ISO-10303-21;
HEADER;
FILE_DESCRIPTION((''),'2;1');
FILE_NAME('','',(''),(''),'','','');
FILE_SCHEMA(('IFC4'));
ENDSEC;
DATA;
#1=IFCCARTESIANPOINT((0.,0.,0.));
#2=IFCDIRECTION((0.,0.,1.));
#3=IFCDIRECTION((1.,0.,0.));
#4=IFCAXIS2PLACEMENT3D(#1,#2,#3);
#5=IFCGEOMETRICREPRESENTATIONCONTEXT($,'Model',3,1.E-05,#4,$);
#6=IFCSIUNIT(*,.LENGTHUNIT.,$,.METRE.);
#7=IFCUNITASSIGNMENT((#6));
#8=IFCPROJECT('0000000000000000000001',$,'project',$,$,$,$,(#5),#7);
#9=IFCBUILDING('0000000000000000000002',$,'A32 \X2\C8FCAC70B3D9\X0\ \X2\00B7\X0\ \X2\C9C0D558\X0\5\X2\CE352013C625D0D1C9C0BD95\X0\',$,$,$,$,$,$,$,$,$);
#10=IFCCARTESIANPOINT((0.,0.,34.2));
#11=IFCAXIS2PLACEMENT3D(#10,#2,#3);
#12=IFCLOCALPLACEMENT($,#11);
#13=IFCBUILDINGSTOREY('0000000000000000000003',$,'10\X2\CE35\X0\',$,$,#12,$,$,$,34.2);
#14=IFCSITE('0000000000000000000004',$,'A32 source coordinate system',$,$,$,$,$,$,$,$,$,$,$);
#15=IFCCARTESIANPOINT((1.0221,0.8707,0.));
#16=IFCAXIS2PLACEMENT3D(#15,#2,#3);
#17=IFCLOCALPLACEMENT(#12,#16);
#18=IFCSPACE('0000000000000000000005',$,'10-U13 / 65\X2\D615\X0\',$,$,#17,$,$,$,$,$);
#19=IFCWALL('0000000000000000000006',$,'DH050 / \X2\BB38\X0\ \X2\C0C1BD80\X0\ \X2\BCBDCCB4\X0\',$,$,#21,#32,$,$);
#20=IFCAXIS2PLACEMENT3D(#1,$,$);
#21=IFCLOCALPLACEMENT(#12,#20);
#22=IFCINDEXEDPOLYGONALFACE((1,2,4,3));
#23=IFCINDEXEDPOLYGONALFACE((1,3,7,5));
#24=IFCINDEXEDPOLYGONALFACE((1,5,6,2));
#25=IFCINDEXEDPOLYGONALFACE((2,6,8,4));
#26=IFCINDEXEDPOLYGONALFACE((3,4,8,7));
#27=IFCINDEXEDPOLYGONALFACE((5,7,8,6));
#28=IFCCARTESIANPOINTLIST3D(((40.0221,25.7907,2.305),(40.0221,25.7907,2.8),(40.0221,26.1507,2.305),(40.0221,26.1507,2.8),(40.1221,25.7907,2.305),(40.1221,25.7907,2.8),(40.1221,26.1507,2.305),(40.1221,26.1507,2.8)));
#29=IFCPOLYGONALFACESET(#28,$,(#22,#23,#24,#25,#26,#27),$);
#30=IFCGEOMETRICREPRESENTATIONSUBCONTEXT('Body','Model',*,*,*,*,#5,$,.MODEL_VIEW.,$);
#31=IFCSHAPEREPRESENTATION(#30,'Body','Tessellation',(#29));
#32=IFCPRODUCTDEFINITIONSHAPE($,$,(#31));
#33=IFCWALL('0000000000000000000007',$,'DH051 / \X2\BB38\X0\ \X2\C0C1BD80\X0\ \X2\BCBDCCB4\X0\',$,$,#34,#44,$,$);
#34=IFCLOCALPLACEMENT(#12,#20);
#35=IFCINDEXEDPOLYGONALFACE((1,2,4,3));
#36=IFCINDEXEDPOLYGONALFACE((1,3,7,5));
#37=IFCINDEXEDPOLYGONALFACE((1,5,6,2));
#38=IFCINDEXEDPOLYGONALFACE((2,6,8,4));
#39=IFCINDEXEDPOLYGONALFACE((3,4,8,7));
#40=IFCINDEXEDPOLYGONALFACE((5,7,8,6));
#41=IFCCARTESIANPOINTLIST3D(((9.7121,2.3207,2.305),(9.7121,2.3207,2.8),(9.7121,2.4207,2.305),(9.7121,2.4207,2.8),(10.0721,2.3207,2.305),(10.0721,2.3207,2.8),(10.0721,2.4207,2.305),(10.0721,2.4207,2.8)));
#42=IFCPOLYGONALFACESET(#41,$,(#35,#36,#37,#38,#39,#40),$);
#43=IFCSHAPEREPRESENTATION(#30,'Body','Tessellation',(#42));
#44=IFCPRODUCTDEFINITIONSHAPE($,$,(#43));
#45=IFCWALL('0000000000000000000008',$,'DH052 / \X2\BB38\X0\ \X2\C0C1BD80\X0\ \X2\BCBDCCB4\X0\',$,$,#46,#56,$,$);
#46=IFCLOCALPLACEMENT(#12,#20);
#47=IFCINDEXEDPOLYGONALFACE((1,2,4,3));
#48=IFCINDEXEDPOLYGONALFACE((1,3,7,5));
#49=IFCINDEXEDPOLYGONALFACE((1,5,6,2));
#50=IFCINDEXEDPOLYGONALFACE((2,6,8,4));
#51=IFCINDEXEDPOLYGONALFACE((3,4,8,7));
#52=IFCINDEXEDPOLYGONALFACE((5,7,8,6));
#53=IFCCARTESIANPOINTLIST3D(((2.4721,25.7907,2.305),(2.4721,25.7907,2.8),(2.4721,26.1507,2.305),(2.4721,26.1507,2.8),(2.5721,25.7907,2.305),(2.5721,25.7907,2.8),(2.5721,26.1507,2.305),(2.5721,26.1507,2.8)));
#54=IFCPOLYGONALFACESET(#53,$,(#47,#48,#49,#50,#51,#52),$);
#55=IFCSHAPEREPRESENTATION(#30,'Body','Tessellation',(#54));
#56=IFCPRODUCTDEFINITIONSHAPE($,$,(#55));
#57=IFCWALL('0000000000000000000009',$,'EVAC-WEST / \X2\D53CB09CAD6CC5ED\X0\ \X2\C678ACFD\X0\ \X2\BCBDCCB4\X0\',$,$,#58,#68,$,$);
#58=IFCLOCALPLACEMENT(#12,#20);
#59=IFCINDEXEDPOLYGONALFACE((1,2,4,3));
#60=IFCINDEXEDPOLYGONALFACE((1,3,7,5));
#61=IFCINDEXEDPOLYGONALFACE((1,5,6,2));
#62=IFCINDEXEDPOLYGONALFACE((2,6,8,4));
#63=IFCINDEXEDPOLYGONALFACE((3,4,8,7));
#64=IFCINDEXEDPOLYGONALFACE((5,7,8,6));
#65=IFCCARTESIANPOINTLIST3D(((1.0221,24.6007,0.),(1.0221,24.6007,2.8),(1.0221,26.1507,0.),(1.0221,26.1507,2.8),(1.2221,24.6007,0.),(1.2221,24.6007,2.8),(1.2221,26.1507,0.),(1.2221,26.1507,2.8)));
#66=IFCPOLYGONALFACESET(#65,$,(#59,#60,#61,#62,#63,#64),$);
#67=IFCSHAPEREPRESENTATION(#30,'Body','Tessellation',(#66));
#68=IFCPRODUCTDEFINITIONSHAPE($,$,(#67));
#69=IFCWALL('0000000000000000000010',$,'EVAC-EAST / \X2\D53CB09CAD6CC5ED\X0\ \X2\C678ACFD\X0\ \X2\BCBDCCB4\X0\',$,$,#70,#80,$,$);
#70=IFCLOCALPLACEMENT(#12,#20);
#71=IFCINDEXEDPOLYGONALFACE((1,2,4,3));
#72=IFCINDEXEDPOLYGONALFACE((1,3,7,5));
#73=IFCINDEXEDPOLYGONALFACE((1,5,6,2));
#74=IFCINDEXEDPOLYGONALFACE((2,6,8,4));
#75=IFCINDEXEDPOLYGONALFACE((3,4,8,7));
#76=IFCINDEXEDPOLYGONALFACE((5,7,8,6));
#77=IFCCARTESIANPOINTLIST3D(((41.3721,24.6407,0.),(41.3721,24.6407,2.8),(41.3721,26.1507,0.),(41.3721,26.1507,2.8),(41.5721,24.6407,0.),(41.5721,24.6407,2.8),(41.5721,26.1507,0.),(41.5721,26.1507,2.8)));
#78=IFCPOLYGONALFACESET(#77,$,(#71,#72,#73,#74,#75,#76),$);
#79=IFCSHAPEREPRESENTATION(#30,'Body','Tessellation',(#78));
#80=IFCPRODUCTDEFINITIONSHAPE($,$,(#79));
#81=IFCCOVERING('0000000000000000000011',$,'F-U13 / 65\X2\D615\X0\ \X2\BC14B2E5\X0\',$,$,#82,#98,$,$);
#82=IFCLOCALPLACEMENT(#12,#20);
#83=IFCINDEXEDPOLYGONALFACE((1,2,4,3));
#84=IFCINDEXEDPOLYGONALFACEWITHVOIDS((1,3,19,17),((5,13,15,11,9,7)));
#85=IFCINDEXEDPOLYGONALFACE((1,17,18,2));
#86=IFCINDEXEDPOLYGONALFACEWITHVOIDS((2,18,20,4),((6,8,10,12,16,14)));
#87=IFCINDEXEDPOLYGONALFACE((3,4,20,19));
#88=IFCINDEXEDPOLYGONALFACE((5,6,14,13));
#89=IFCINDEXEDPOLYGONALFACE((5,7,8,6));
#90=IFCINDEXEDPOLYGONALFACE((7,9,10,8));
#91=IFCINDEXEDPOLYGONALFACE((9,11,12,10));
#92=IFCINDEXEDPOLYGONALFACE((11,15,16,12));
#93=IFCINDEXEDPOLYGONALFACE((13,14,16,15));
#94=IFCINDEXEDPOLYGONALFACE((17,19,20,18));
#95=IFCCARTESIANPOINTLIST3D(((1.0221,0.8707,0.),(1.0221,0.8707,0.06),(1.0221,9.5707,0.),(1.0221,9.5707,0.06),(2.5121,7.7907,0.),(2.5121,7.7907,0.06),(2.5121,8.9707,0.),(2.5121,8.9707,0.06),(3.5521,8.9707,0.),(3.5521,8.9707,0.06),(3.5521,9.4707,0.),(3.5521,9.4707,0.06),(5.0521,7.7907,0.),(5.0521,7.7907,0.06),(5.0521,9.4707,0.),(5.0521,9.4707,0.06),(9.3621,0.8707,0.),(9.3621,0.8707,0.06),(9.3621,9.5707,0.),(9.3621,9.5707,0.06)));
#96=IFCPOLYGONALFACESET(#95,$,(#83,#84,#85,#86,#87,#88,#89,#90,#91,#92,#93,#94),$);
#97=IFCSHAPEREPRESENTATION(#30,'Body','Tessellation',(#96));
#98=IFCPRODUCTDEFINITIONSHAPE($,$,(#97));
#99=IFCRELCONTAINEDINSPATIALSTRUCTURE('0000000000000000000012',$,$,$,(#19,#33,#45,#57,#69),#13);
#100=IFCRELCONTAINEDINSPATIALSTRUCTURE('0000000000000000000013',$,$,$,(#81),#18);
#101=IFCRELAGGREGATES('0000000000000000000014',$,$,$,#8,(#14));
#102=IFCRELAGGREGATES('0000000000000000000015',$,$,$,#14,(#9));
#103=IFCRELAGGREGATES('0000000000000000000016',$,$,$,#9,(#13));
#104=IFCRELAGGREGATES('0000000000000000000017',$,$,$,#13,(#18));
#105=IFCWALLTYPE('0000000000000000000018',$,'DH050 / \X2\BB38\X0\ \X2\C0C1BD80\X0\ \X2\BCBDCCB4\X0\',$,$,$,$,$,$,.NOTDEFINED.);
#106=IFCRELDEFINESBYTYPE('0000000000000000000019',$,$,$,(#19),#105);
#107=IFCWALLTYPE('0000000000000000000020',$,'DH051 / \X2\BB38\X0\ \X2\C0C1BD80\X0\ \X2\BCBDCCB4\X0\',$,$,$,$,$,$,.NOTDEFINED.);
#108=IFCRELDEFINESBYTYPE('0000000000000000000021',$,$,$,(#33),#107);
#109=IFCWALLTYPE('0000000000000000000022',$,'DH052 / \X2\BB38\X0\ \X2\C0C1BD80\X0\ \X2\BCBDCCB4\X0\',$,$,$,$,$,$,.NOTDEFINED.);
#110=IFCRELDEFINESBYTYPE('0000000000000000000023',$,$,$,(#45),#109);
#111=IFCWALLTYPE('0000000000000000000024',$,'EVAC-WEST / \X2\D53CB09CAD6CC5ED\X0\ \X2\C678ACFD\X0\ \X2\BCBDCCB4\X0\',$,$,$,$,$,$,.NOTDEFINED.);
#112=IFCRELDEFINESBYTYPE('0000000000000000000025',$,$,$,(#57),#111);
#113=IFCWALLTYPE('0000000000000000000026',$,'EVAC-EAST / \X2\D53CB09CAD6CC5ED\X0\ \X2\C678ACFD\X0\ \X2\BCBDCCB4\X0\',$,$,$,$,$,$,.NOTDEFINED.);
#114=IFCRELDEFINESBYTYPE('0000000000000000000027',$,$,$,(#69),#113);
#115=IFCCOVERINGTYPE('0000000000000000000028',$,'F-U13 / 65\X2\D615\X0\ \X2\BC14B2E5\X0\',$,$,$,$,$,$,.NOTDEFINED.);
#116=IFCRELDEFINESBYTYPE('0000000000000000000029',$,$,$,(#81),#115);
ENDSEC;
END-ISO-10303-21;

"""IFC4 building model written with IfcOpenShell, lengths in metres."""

from ifc_helpers import new_model, si_unit, frame, origin, origin_with_axes, place, context, subcontext, project, spatial, polyline, outline, extrude, source, transform, mapped, type_object, type_shapes, element, save


model = new_model("IFC4")

# Units and contexts
model_context = context("Model", 3, precision=1e-05, world=origin_with_axes())
body_context = subcontext(model_context, "Body", "Model", "MODEL_VIEW")
ifc_project = project(units=[si_unit("LENGTHUNIT", "METRE")], contexts=[model_context])

# Site, building, storey
site = spatial("IfcSite", under=ifc_project, Name="A32 source coordinate system")
building = spatial("IfcBuilding", under=site, Name="A32 주거동 · 지하5층–옥탑지붕")
storey_placement = place(None, frame((0.0, 0.0, 34.2), z_axis=(0.0, 0.0, 1.0), x_axis=(1.0, 0.0, 0.0)))
storey = spatial("IfcBuildingStorey", under=building, at=storey_placement, Name="10층", Elevation=34.2)

# Walls
wall_type_1 = type_object("IfcWallType", Name="DH050 / 문 상부 벽체", PredefinedType="NOTDEFINED")
shared_shape_1 = source(origin(), body_context, "Body", "SweptSolid", [
    extrude(outline(polyline([(40.0221, 25.7907), (40.0221, 26.1507), (40.1221, 26.1507), (40.1221, 25.7907), (40.0221, 25.7907)])), frame((0.0, 0.0, 2.305)), (0.0, 0.0, 1.0), 0.495),
])
type_shapes(wall_type_1, [shared_shape_1])
wall_1_placement = place(storey_placement, origin_with_axes())
element("IfcWall", 1, at=wall_1_placement, inside=storey, type_object=wall_type_1, Name="DH050 / 문 상부 벽체", context=body_context, shape_type="MappedRepresentation", body=[
    mapped(shared_shape_1, transform((0.0, 0.0, 0.0), scale=1.0)),
])
wall_type_2 = type_object("IfcWallType", Name="DH051 / 문 상부 벽체", PredefinedType="NOTDEFINED")
shared_shape_2 = source(origin(), body_context, "Body", "SweptSolid", [
    extrude(outline(polyline([(10.0721, 2.3207), (9.7121, 2.3207), (9.7121, 2.4207), (10.0721, 2.4207), (10.0721, 2.3207)])), frame((0.0, 0.0, 2.305)), (0.0, 0.0, 1.0), 0.495),
])
type_shapes(wall_type_2, [shared_shape_2])
wall_2_placement = place(storey_placement, origin_with_axes())
element("IfcWall", 2, at=wall_2_placement, inside=storey, type_object=wall_type_2, Name="DH051 / 문 상부 벽체", context=body_context, shape_type="MappedRepresentation", body=[
    mapped(shared_shape_2, transform((0.0, 0.0, 0.0), scale=1.0)),
])
wall_type_3 = type_object("IfcWallType", Name="DH052 / 문 상부 벽체", PredefinedType="NOTDEFINED")
shared_shape_3 = source(origin(), body_context, "Body", "SweptSolid", [
    extrude(outline(polyline([(2.5721, 25.7907), (2.4721, 25.7907), (2.4721, 26.1507), (2.5721, 26.1507), (2.5721, 25.7907)])), frame((0.0, 0.0, 2.305)), (0.0, 0.0, 1.0), 0.495),
])
type_shapes(wall_type_3, [shared_shape_3])
wall_3_placement = place(storey_placement, origin_with_axes())
element("IfcWall", 3, at=wall_3_placement, inside=storey, type_object=wall_type_3, Name="DH052 / 문 상부 벽체", context=body_context, shape_type="MappedRepresentation", body=[
    mapped(shared_shape_3, transform((0.0, 0.0, 0.0), scale=1.0)),
])
wall_type_4 = type_object("IfcWallType", Name="EVAC-WEST / 피난구역 외곽 벽체", PredefinedType="NOTDEFINED")
shared_shape_4 = source(origin(), body_context, "Body", "SweptSolid", [
    extrude(outline(polyline([(1.2221, 24.6007), (1.0221, 24.6007), (1.0221, 26.1507), (1.2221, 26.1507), (1.2221, 24.6007)])), origin(), (0.0, 0.0, 1.0), 2.8),
])
type_shapes(wall_type_4, [shared_shape_4])
wall_4_placement = place(storey_placement, origin_with_axes())
element("IfcWall", 4, at=wall_4_placement, inside=storey, type_object=wall_type_4, Name="EVAC-WEST / 피난구역 외곽 벽체", context=body_context, shape_type="MappedRepresentation", body=[
    mapped(shared_shape_4, transform((0.0, 0.0, 0.0), scale=1.0)),
])
wall_type_5 = type_object("IfcWallType", Name="EVAC-EAST / 피난구역 외곽 벽체", PredefinedType="NOTDEFINED")
shared_shape_5 = source(origin(), body_context, "Body", "SweptSolid", [
    extrude(outline(polyline([(41.5721, 26.1507), (41.5721, 24.6407), (41.3721, 24.6407), (41.3721, 26.1507), (41.5721, 26.1507)])), origin(), (0.0, 0.0, 1.0), 2.8),
])
type_shapes(wall_type_5, [shared_shape_5])
wall_5_placement = place(storey_placement, origin_with_axes())
element("IfcWall", 5, at=wall_5_placement, inside=storey, type_object=wall_type_5, Name="EVAC-EAST / 피난구역 외곽 벽체", context=body_context, shape_type="MappedRepresentation", body=[
    mapped(shared_shape_5, transform((0.0, 0.0, 0.0), scale=1.0)),
])

# Shared definitions
space_placement = place(storey_placement, frame((1.0221, 0.8707, 0.0), z_axis=(0.0, 0.0, 1.0), x_axis=(1.0, 0.0, 0.0)))
space = spatial("IfcSpace", under=storey, at=space_placement, Name="10-U13 / 65형")

# Covering
covering_type_1 = type_object("IfcCoveringType", Name="F-U13 / 65형 바닥", PredefinedType="NOTDEFINED")
shared_shape_6 = source(origin(), body_context, "Body", "SweptSolid", [
    extrude(outline(polyline([(0.0, 0.0), (0.0, 8.7), (8.34, 8.7), (8.34, 0.0), (0.0, 0.0)]), holes=[polyline([(2.53, 8.1), (1.49, 8.1), (1.49, 6.92), (4.03, 6.92), (4.03, 8.6), (2.53, 8.6), (2.53, 8.1)])]), origin(), (0.0, 0.0, 1.0), 0.06),
])
type_shapes(covering_type_1, [shared_shape_6])
covering_1_placement = place(space_placement, origin_with_axes())
element("IfcCovering", 6, at=covering_1_placement, inside=space, type_object=covering_type_1, Name="F-U13 / 65형 바닥", context=body_context, shape_type="MappedRepresentation", body=[
    mapped(shared_shape_6, transform((0.0, 0.0, 0.0), scale=1.0)),
])

save(model, "model.ifc")
